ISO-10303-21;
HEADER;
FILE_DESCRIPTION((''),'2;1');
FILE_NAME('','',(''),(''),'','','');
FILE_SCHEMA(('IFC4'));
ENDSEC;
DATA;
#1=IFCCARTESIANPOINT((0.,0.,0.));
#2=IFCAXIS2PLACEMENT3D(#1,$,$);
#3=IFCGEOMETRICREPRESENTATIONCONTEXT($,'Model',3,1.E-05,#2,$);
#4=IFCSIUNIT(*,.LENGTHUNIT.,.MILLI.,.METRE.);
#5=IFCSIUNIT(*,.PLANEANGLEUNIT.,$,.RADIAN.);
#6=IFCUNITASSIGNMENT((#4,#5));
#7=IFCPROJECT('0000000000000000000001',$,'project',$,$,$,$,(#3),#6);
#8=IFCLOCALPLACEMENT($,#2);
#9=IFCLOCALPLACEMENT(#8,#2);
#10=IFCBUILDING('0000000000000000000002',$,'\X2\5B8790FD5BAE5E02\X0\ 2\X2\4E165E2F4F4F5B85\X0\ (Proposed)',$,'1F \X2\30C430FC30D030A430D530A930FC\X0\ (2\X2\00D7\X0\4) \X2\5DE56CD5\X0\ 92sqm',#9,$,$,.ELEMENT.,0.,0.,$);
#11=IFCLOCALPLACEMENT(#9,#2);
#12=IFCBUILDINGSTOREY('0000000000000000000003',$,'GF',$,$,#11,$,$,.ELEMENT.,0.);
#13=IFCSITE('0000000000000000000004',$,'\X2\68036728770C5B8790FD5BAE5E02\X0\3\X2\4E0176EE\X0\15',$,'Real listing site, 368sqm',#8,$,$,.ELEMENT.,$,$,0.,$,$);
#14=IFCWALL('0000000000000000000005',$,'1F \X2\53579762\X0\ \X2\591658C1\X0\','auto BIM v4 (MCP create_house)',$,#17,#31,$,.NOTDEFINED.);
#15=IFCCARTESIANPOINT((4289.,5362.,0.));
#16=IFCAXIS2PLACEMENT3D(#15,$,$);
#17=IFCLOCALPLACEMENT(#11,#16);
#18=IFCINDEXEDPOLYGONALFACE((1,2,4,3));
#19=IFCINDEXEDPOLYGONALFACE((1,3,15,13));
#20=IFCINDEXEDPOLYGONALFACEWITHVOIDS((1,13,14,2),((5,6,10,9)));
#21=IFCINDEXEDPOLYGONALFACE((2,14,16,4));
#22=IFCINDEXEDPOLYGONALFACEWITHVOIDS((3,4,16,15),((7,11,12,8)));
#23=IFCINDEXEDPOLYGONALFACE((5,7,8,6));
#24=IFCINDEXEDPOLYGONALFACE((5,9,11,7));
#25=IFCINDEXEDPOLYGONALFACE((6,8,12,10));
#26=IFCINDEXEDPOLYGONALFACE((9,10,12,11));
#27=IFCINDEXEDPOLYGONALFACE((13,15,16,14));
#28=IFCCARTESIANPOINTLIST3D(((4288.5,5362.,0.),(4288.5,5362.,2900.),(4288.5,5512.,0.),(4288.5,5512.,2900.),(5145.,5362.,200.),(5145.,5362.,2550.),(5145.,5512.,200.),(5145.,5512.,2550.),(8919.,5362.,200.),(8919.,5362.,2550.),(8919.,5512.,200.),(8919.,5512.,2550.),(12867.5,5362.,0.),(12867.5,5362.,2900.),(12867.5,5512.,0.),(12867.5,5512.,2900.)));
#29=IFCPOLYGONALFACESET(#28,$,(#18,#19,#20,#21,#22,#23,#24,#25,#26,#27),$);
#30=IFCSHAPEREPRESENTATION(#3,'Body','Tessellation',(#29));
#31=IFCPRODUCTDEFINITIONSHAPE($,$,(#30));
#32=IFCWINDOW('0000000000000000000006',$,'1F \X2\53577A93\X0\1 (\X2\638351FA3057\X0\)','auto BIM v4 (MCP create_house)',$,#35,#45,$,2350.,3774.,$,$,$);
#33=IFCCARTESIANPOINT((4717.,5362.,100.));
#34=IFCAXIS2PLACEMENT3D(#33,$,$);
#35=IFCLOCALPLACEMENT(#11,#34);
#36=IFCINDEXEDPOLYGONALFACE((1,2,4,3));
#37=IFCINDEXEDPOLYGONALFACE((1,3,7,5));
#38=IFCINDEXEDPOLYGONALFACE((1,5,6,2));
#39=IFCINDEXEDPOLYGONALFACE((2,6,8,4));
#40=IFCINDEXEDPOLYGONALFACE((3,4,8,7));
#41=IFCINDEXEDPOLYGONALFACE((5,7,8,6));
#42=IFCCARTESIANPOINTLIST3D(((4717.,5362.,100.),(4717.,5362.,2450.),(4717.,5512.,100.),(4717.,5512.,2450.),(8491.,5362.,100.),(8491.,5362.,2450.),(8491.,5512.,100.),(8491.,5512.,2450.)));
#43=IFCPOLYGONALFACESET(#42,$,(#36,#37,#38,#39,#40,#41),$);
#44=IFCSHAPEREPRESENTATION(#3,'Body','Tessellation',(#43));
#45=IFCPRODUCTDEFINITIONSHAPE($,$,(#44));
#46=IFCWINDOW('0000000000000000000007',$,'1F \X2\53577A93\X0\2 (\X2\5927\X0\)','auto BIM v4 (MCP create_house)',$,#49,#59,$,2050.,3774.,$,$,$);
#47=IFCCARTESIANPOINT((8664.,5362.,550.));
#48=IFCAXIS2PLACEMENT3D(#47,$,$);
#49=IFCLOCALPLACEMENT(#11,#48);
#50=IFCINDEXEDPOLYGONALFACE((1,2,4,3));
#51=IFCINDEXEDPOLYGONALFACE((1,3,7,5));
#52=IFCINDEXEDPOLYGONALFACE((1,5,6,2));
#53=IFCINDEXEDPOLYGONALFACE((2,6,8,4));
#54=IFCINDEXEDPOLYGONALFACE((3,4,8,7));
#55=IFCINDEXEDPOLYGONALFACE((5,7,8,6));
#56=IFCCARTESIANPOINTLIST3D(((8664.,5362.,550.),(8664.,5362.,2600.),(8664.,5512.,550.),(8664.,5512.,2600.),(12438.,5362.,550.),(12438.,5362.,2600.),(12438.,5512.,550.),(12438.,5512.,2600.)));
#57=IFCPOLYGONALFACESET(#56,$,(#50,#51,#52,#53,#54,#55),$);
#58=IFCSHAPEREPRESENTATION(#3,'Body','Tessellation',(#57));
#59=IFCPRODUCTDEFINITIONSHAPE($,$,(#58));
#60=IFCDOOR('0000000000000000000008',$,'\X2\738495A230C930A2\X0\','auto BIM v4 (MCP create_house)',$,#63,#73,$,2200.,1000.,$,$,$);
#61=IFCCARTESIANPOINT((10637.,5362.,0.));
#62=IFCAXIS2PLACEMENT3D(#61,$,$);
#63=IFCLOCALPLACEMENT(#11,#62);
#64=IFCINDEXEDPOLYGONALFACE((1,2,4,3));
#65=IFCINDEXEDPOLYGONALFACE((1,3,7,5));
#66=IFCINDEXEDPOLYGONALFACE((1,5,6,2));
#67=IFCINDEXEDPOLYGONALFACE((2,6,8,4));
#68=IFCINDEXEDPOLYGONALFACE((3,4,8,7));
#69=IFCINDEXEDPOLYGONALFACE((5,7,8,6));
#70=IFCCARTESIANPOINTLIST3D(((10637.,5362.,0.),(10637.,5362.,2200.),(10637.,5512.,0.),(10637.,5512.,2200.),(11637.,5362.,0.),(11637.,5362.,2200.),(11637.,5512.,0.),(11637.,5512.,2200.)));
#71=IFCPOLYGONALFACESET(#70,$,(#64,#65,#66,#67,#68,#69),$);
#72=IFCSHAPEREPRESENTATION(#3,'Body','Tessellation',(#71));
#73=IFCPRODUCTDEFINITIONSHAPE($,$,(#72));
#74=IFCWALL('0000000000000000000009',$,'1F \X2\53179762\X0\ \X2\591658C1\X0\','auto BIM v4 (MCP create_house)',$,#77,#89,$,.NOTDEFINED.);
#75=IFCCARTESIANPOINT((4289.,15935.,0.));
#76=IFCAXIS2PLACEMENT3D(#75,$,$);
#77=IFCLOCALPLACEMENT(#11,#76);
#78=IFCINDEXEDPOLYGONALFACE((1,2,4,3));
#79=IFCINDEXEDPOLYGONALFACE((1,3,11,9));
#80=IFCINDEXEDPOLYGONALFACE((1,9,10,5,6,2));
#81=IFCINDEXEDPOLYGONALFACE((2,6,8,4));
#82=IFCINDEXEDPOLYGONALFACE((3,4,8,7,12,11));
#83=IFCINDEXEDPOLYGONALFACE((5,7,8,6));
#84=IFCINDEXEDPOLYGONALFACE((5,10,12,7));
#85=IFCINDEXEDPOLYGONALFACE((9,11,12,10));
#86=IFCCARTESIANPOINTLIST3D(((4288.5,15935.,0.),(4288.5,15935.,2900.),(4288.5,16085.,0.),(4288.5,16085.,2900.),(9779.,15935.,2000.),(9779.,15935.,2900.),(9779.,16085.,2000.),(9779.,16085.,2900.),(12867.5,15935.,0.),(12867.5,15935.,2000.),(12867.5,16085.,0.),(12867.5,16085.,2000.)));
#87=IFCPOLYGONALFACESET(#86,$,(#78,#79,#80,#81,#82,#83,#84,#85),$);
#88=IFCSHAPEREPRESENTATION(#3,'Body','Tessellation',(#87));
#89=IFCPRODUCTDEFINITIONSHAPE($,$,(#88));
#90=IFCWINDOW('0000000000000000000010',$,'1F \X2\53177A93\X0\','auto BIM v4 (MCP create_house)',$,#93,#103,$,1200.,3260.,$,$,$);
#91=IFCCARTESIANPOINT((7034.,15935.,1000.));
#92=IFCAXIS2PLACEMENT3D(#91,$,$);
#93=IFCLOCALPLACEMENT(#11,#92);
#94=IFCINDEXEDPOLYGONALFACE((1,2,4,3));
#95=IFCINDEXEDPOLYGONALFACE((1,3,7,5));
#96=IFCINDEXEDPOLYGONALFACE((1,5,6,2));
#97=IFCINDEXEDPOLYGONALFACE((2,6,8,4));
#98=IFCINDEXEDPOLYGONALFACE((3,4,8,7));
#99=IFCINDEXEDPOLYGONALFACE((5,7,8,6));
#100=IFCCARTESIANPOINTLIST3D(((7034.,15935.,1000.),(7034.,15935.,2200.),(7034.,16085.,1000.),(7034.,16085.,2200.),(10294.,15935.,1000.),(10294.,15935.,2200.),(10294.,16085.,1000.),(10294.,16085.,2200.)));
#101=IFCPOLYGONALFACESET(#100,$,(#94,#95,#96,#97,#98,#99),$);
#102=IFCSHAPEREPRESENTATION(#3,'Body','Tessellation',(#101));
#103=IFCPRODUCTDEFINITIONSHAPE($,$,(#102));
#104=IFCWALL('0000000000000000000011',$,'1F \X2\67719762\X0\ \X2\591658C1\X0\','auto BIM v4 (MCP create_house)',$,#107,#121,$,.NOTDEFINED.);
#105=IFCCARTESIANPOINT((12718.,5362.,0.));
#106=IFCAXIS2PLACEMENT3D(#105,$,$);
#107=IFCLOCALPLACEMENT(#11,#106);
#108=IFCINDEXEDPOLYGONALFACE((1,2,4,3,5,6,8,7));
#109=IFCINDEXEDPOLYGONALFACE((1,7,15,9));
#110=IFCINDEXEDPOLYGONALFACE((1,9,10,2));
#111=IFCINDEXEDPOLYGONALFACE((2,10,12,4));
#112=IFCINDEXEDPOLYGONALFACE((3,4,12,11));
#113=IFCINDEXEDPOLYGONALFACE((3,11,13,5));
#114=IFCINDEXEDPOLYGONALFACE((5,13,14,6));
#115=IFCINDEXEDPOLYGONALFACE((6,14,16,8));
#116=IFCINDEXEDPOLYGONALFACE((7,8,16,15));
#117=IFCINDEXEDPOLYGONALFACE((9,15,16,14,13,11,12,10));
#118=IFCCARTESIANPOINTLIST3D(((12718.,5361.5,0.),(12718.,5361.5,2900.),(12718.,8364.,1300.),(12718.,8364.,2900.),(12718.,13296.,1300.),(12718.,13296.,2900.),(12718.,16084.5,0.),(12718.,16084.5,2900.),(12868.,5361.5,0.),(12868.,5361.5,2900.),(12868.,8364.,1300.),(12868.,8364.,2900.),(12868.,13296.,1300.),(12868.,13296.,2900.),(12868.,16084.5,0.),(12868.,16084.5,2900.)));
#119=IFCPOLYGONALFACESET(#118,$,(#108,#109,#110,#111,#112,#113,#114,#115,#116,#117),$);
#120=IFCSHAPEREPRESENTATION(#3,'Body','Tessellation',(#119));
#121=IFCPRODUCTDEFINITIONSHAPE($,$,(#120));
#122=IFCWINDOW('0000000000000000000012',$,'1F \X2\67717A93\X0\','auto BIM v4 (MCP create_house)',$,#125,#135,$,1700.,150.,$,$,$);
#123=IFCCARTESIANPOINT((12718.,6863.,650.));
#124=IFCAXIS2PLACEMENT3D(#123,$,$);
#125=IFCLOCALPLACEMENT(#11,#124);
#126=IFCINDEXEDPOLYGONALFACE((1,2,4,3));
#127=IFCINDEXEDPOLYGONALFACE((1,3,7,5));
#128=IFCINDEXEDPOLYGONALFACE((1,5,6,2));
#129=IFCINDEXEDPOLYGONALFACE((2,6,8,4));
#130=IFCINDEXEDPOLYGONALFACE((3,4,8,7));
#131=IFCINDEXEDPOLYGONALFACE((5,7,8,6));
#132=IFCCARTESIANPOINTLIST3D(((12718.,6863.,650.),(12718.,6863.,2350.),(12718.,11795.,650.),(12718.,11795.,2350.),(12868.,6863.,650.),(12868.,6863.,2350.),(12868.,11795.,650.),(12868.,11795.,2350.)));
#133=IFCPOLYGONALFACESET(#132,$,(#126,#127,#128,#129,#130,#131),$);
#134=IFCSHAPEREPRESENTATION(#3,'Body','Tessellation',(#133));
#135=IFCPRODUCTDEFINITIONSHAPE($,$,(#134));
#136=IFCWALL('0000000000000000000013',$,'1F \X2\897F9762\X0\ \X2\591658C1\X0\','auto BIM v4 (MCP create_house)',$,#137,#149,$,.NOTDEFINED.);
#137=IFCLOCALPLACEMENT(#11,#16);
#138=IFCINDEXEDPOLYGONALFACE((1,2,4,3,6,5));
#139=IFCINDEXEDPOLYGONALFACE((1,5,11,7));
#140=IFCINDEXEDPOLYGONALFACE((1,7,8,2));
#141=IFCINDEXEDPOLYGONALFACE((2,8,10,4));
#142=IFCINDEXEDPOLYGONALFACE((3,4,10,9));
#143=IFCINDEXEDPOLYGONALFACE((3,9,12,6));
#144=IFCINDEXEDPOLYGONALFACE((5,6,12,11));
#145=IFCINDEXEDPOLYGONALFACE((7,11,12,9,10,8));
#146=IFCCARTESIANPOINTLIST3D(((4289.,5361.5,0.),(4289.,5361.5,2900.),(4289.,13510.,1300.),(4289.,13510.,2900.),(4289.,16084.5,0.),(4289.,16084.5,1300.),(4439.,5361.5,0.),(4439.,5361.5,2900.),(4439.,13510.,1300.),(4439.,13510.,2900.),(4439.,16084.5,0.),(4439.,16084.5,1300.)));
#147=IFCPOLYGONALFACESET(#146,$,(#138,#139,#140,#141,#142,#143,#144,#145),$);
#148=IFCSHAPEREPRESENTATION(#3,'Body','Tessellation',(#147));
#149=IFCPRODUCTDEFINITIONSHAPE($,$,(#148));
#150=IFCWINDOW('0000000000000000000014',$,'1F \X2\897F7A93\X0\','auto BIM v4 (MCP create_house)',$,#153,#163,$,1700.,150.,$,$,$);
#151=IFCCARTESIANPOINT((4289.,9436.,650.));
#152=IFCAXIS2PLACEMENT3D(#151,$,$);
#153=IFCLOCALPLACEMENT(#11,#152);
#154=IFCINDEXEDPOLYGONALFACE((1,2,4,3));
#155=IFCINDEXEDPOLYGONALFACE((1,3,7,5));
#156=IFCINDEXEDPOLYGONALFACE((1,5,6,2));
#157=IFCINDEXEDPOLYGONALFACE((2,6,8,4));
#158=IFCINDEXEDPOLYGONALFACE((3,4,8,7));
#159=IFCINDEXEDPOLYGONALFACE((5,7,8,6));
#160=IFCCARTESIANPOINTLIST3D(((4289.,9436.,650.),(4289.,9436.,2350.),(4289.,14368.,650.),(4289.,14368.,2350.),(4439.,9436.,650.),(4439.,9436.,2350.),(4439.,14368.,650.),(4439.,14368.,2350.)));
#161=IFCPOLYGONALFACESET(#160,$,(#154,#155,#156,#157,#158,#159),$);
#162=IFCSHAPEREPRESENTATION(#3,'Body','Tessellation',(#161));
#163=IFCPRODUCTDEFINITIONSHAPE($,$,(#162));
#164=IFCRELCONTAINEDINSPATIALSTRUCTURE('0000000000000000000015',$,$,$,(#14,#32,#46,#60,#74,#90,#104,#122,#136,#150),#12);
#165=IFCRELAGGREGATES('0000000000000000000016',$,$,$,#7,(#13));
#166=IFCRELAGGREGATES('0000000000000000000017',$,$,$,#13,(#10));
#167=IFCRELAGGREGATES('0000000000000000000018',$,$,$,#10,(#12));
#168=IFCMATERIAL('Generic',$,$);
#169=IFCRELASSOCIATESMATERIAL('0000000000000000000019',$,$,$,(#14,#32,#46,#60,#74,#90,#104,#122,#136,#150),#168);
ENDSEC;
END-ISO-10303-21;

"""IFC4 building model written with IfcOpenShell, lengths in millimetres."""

from ifc_helpers import new_model, si_unit, frame, frame_2d, origin, place, context, project, spatial, rectangle, extrude, material, element, fill, save


model = new_model("IFC4")

# Units and contexts
model_context = context("Model", 3, precision=1e-05, world=origin())
ifc_project = project(units=[si_unit("LENGTHUNIT", "METRE", prefix="MILLI"), si_unit("PLANEANGLEUNIT", "RADIAN")], contexts=[model_context])

# Site, building, storey
site_placement = place(None, origin())
site = spatial("IfcSite", under=ifc_project, at=site_placement, Name="栃木県宇都宮市3丁目15", ObjectType="Real listing site, 368sqm", CompositionType="ELEMENT", RefElevation=0.0)
building_placement = place(site_placement, origin())
building = spatial("IfcBuilding", under=site, at=building_placement, Name="宇都宮市 2世帯住宅 (Proposed)", ObjectType="1F ツーバイフォー (2×4) 工法 92sqm", CompositionType="ELEMENT", ElevationOfRefHeight=0.0, ElevationOfTerrain=0.0)
storey_placement = place(building_placement, origin())
storey = spatial("IfcBuildingStorey", under=building, at=storey_placement, Name="GF", CompositionType="ELEMENT", Elevation=0.0)

# Shared definitions
ifc_material = material(Name="Generic")

# Wall, openings, windows, door
wall_1_placement = place(storey_placement, frame((4289.0, 5362.0, 0.0)))
wall_1 = element("IfcWall", 1, at=wall_1_placement, inside=storey, material=ifc_material, Name="1F 南面 外壁", Description="auto BIM v4 (MCP create_house)", PredefinedType="NOTDEFINED", context=model_context, shape_type="SweptSolid", body=[
    extrude(rectangle(XDim=8579.0, YDim=150.0, at=frame_2d((4289.0, 75.0))), frame((4289.0, 5362.0, 0.0)), (0.0, 0.0, 1.0), 2900.0),
])
opening_1_placement = place(storey_placement, frame((4717.0, 5362.0, 100.0)))
opening_1 = element("IfcOpeningElement", 2, at=opening_1_placement, cuts=wall_1, PredefinedType="NOTDEFINED", context=model_context, shape_type="SweptSolid", body=[
    extrude(rectangle(XDim=3774.0, YDim=150.0, at=frame_2d((1887.0, 75.0))), frame((4717.0, 5362.0, 100.0)), (0.0, 0.0, 1.0), 2350.0),
])
opening_2_placement = place(storey_placement, frame((8664.0, 5362.0, 550.0)))
opening_2 = element("IfcOpeningElement", 3, at=opening_2_placement, cuts=wall_1, PredefinedType="NOTDEFINED", context=model_context, shape_type="SweptSolid", body=[
    extrude(rectangle(XDim=3774.0, YDim=150.0, at=frame_2d((1887.0, 75.0))), frame((8664.0, 5362.0, 550.0)), (0.0, 0.0, 1.0), 2050.0),
])
opening_3_placement = place(storey_placement, frame((10637.0, 5362.0, 0.0)))
opening_3 = element("IfcOpeningElement", 4, at=opening_3_placement, cuts=wall_1, PredefinedType="NOTDEFINED", context=model_context, shape_type="SweptSolid", body=[
    extrude(rectangle(XDim=1000.0, YDim=150.0, at=frame_2d((500.0, 75.0))), frame((10637.0, 5362.0, 0.0)), (0.0, 0.0, 1.0), 2200.0),
])
window_1_placement = place(storey_placement, frame((4717.0, 5362.0, 100.0)))
window_1 = element("IfcWindow", 5, at=window_1_placement, inside=storey, material=ifc_material, Name="1F 南窓1 (掃出し)", Description="auto BIM v4 (MCP create_house)", OverallHeight=2350.0, OverallWidth=3774.0, context=model_context, shape_type="SweptSolid", body=[
    extrude(rectangle(XDim=3774.0, YDim=150.0, at=frame_2d((1887.0, 75.0))), frame((4717.0, 5362.0, 100.0)), (0.0, 0.0, 1.0), 2350.0),
])
fill(opening_1, window_1)
window_2_placement = place(storey_placement, frame((8664.0, 5362.0, 550.0)))
window_2 = element("IfcWindow", 6, at=window_2_placement, inside=storey, material=ifc_material, Name="1F 南窓2 (大)", Description="auto BIM v4 (MCP create_house)", OverallHeight=2050.0, OverallWidth=3774.0, context=model_context, shape_type="SweptSolid", body=[
    extrude(rectangle(XDim=3774.0, YDim=150.0, at=frame_2d((1887.0, 75.0))), frame((8664.0, 5362.0, 550.0)), (0.0, 0.0, 1.0), 2050.0),
])
fill(opening_2, window_2)
door_placement = place(storey_placement, frame((10637.0, 5362.0, 0.0)))
door = element("IfcDoor", 7, at=door_placement, inside=storey, material=ifc_material, Name="玄関ドア", Description="auto BIM v4 (MCP create_house)", OverallHeight=2200.0, OverallWidth=1000.0, context=model_context, shape_type="SweptSolid", body=[
    extrude(rectangle(XDim=1000.0, YDim=150.0, at=frame_2d((500.0, 75.0))), frame((10637.0, 5362.0, 0.0)), (0.0, 0.0, 1.0), 2200.0),
])
fill(opening_3, door)

# Walls, openings, windows
wall_2_placement = place(storey_placement, frame((4289.0, 15935.0, 0.0)))
wall_2 = element("IfcWall", 8, at=wall_2_placement, inside=storey, material=ifc_material, Name="1F 北面 外壁", Description="auto BIM v4 (MCP create_house)", PredefinedType="NOTDEFINED", context=model_context, shape_type="SweptSolid", body=[
    extrude(rectangle(XDim=8579.0, YDim=150.0, at=frame_2d((4289.0, 75.0))), frame((4289.0, 15935.0, 0.0)), (0.0, 0.0, 1.0), 2900.0),
])
opening_4_placement = place(storey_placement, frame((7034.0, 15935.0, 1000.0)))
opening_4 = element("IfcOpeningElement", 9, at=opening_4_placement, cuts=wall_2, PredefinedType="NOTDEFINED", context=model_context, shape_type="SweptSolid", body=[
    extrude(rectangle(XDim=3260.0, YDim=150.0, at=frame_2d((1630.0, 75.0))), frame((7034.0, 15935.0, 1000.0)), (0.0, 0.0, 1.0), 1200.0),
])
window_3_placement = place(storey_placement, frame((7034.0, 15935.0, 1000.0)))
window_3 = element("IfcWindow", 10, at=window_3_placement, inside=storey, material=ifc_material, Name="1F 北窓", Description="auto BIM v4 (MCP create_house)", OverallHeight=1200.0, OverallWidth=3260.0, context=model_context, shape_type="SweptSolid", body=[
    extrude(rectangle(XDim=3260.0, YDim=150.0, at=frame_2d((1630.0, 75.0))), frame((7034.0, 15935.0, 1000.0)), (0.0, 0.0, 1.0), 1200.0),
])
fill(opening_4, window_3)
wall_3_placement = place(storey_placement, frame((12718.0, 5362.0, 0.0)))
wall_3 = element("IfcWall", 11, at=wall_3_placement, inside=storey, material=ifc_material, Name="1F 東面 外壁", Description="auto BIM v4 (MCP create_house)", PredefinedType="NOTDEFINED", context=model_context, shape_type="SweptSolid", body=[
    extrude(rectangle(XDim=150.0, YDim=10723.0, at=frame_2d((75.0, 5361.0))), frame((12718.0, 5362.0, 0.0)), (0.0, 0.0, 1.0), 2900.0),
])
opening_5_placement = place(storey_placement, frame((12718.0, 6863.0, 650.0)))
opening_5 = element("IfcOpeningElement", 12, at=opening_5_placement, cuts=wall_3, PredefinedType="NOTDEFINED", context=model_context, shape_type="SweptSolid", body=[
    extrude(rectangle(XDim=150.0, YDim=4932.0, at=frame_2d((75.0, 2466.0))), frame((12718.0, 6863.0, 650.0)), (0.0, 0.0, 1.0), 1700.0),
])
window_4_placement = place(storey_placement, frame((12718.0, 6863.0, 650.0)))
window_4 = element("IfcWindow", 13, at=window_4_placement, inside=storey, material=ifc_material, Name="1F 東窓", Description="auto BIM v4 (MCP create_house)", OverallHeight=1700.0, OverallWidth=150.0, context=model_context, shape_type="SweptSolid", body=[
    extrude(rectangle(XDim=150.0, YDim=4932.0, at=frame_2d((75.0, 2466.0))), frame((12718.0, 6863.0, 650.0)), (0.0, 0.0, 1.0), 1700.0),
])
fill(opening_5, window_4)
wall_4_placement = place(storey_placement, frame((4289.0, 5362.0, 0.0)))
wall_4 = element("IfcWall", 14, at=wall_4_placement, inside=storey, material=ifc_material, Name="1F 西面 外壁", Description="auto BIM v4 (MCP create_house)", PredefinedType="NOTDEFINED", context=model_context, shape_type="SweptSolid", body=[
    extrude(rectangle(XDim=150.0, YDim=10723.0, at=frame_2d((75.0, 5361.0))), frame((4289.0, 5362.0, 0.0)), (0.0, 0.0, 1.0), 2900.0),
])
opening_6_placement = place(storey_placement, frame((4289.0, 9436.0, 650.0)))
opening_6 = element("IfcOpeningElement", 15, at=opening_6_placement, cuts=wall_4, PredefinedType="NOTDEFINED", context=model_context, shape_type="SweptSolid", body=[
    extrude(rectangle(XDim=150.0, YDim=4932.0, at=frame_2d((75.0, 2466.0))), frame((4289.0, 9436.0, 650.0)), (0.0, 0.0, 1.0), 1700.0),
])
window_5_placement = place(storey_placement, frame((4289.0, 9436.0, 650.0)))
window_5 = element("IfcWindow", 16, at=window_5_placement, inside=storey, material=ifc_material, Name="1F 西窓", Description="auto BIM v4 (MCP create_house)", OverallHeight=1700.0, OverallWidth=150.0, context=model_context, shape_type="SweptSolid", body=[
    extrude(rectangle(XDim=150.0, YDim=4932.0, at=frame_2d((75.0, 2466.0))), frame((4289.0, 9436.0, 650.0)), (0.0, 0.0, 1.0), 1700.0),
])
fill(opening_6, window_5)

save(model, "model.ifc")
